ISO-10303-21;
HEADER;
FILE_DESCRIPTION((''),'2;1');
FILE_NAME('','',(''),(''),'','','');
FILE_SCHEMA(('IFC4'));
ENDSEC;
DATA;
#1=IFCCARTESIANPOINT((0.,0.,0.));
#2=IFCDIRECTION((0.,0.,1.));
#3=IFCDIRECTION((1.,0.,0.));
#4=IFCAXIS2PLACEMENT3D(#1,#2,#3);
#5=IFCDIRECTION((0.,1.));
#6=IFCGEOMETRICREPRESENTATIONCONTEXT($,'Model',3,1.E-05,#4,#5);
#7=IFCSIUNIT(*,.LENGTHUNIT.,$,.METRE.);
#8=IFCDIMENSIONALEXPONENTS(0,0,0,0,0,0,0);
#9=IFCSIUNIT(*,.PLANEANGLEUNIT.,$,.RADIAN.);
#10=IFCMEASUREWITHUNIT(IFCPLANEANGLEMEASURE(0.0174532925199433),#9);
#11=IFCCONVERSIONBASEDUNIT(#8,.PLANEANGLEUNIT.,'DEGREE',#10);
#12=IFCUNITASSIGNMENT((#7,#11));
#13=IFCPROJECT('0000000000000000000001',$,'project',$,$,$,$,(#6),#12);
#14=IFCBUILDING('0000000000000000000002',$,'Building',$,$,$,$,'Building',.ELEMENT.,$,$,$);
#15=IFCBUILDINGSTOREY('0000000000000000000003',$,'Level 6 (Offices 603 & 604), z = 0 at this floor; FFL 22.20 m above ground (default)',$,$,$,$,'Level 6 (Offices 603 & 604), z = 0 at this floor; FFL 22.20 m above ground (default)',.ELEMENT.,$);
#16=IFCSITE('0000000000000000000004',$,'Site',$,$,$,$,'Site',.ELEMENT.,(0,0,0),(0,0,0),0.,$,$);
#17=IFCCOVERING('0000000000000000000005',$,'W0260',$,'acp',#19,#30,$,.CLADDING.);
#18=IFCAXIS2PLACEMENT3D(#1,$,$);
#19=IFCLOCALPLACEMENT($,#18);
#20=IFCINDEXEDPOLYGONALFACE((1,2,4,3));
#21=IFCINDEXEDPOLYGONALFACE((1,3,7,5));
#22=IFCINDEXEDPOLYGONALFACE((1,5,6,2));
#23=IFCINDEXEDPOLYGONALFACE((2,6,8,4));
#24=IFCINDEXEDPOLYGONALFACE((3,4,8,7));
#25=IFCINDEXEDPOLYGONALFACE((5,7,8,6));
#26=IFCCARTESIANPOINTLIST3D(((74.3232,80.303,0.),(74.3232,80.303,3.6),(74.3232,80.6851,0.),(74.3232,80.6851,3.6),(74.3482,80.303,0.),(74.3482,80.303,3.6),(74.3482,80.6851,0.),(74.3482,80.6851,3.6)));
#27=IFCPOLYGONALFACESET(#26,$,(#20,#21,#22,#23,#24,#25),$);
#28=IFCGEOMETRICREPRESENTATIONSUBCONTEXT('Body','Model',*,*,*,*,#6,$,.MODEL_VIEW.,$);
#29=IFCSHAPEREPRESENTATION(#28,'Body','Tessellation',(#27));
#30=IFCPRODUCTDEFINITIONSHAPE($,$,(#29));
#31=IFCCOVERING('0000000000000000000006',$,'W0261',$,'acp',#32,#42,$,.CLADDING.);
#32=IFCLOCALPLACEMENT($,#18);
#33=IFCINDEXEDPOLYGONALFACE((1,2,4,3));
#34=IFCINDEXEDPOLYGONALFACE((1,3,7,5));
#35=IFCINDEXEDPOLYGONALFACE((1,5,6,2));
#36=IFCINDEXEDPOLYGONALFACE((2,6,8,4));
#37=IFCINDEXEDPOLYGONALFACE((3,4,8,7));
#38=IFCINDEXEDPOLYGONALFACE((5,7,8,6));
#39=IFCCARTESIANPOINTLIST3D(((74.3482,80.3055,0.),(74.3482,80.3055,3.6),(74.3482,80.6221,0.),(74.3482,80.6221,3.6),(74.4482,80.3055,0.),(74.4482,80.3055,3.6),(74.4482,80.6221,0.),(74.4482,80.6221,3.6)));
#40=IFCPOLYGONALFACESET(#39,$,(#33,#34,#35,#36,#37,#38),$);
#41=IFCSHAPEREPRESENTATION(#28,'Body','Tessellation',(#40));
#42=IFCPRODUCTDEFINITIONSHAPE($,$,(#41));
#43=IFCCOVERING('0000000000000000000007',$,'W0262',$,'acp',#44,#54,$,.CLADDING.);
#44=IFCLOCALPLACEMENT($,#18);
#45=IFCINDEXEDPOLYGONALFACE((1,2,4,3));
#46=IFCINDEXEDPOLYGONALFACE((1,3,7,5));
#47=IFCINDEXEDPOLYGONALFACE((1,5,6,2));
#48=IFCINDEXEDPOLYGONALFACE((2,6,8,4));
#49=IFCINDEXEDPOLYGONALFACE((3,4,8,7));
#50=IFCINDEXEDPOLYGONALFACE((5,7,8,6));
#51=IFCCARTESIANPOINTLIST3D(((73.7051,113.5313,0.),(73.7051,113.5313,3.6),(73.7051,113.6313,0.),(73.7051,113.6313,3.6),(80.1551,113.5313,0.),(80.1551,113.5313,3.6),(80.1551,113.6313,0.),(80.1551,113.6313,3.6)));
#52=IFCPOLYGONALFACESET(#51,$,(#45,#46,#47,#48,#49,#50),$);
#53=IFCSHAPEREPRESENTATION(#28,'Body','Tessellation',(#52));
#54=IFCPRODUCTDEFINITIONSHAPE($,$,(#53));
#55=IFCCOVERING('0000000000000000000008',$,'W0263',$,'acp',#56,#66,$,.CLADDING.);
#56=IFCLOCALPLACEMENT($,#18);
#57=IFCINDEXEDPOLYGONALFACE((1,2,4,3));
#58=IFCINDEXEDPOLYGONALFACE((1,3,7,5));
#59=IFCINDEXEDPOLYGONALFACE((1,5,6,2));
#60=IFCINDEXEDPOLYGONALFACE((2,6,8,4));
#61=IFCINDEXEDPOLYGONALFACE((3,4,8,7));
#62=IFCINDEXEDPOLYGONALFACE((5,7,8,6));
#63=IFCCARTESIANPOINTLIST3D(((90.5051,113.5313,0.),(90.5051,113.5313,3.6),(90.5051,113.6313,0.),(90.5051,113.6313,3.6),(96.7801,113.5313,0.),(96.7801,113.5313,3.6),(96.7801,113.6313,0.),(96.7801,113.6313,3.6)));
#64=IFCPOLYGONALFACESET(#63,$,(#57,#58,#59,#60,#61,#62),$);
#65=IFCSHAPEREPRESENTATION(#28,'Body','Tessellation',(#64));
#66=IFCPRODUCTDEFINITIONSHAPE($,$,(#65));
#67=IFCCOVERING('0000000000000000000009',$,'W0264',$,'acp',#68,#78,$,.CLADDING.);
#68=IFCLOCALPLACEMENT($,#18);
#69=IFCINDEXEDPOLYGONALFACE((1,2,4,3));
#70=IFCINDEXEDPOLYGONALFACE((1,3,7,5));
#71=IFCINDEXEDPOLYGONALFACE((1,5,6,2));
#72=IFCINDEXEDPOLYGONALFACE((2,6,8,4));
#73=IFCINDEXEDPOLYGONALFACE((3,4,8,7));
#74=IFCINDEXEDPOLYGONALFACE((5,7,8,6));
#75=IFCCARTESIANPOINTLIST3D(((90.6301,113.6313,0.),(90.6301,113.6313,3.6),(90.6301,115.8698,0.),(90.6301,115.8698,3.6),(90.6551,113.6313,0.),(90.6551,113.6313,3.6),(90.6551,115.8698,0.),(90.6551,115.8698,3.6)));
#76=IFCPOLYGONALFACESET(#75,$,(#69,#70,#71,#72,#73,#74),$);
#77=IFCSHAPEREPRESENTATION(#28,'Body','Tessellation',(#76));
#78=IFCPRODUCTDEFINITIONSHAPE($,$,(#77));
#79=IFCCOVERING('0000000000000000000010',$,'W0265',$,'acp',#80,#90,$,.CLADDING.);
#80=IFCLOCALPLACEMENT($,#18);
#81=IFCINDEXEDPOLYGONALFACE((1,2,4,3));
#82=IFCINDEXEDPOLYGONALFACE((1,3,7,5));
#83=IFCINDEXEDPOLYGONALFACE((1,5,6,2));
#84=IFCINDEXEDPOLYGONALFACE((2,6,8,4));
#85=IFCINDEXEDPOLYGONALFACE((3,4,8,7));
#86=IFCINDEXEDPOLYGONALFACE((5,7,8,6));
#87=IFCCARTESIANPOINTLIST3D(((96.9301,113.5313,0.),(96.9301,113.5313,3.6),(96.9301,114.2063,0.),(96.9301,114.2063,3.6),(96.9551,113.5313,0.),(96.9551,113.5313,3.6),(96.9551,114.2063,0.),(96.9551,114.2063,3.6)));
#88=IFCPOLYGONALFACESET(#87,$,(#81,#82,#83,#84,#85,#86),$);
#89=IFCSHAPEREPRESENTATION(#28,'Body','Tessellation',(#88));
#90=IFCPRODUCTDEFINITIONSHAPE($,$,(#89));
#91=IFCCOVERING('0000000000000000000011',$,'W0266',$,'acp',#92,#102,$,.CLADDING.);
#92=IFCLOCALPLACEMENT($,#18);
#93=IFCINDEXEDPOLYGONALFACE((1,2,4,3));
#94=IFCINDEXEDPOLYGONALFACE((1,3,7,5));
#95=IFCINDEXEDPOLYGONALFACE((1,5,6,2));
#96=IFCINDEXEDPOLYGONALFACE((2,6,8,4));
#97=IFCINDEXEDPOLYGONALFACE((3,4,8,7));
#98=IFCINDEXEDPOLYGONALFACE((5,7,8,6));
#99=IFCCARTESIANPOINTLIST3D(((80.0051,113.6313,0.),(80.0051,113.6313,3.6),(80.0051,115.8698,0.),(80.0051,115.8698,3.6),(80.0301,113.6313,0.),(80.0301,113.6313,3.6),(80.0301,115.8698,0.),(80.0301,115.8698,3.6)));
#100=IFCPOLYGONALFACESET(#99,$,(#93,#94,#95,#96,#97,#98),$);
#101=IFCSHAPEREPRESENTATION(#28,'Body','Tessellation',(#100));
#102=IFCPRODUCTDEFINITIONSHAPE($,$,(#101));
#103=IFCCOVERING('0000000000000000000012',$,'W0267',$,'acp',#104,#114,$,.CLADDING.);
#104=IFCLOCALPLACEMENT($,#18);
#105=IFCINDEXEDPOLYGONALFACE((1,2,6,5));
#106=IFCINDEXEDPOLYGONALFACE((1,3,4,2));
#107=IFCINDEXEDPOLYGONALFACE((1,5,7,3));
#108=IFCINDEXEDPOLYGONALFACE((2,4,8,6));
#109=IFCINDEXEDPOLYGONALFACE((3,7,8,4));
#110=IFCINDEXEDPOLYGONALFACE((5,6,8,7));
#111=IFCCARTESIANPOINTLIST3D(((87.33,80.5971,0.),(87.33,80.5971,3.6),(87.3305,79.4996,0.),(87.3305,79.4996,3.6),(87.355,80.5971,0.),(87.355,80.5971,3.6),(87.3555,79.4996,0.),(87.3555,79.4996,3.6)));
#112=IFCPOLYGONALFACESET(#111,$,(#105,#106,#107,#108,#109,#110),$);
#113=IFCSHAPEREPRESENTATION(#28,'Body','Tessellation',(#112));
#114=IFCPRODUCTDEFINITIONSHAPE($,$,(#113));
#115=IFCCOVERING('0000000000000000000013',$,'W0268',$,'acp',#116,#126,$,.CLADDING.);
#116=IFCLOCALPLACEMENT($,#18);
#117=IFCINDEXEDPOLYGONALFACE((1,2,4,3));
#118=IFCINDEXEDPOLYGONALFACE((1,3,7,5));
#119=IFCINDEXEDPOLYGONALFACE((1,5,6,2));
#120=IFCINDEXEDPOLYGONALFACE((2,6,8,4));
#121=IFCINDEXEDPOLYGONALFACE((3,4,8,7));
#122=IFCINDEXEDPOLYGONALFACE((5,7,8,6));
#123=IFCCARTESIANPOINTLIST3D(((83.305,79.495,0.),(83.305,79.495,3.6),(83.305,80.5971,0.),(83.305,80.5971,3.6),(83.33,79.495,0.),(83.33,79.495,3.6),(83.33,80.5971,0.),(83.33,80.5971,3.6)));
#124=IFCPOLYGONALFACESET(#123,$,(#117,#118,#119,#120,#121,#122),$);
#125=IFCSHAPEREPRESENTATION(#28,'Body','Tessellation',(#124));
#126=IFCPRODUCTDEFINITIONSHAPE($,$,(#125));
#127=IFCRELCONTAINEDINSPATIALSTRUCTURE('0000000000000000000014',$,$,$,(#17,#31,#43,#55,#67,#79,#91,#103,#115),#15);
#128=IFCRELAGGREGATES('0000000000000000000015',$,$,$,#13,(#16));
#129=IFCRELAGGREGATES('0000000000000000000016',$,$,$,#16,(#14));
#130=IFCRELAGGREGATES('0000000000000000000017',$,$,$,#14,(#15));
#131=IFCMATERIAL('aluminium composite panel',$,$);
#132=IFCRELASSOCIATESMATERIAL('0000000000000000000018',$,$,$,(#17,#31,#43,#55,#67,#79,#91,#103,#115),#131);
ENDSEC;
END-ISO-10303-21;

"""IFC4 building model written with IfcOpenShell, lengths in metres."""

from ifc_helpers import new_model, entity, si_unit, converted_unit, direction, frame, frame_2d, origin_with_axes, place, context, subcontext, project, spatial, rectangle, extrude, material, element, save


model = new_model("IFC4")

# Units and contexts
model_context = context("Model", 3, precision=1e-05, world=origin_with_axes(), true_north=direction((0.0, 1.0)))
body_context = subcontext(model_context, "Body", "Model", "MODEL_VIEW")
ifc_project = project(units=[si_unit("LENGTHUNIT", "METRE"), converted_unit("PLANEANGLEUNIT", "DEGREE", entity("IfcPlaneAngleMeasure", 0.0174532925199433), si_unit("PLANEANGLEUNIT", "RADIAN"), dimensions=[0, 0, 0, 0, 0, 0, 0])], contexts=[model_context])

# Site, building, storey
site = spatial("IfcSite", under=ifc_project, Name="Site", LongName="Site", CompositionType="ELEMENT", RefLatitude=(0, 0, 0), RefLongitude=(0, 0, 0), RefElevation=0.0)
building = spatial("IfcBuilding", under=site, Name="Building", LongName="Building", CompositionType="ELEMENT")
storey = spatial("IfcBuildingStorey", under=building, Name="Level 6 (Offices 603 & 604), z = 0 at this floor; FFL 22.20 m above ground (default)", LongName="Level 6 (Offices 603 & 604), z = 0 at this floor; FFL 22.20 m above ground (default)", CompositionType="ELEMENT")

# Shared definitions
placement = place(None, origin_with_axes())

# Coverings
ifc_material_1 = material(Name="aluminium composite panel")
element("IfcCovering", 1, at=placement, inside=storey, material=ifc_material_1, Name="W0260", ObjectType="acp", PredefinedType="CLADDING", context=body_context, shape_type="SweptSolid", body=[
    extrude(rectangle(XDim=0.3821, YDim=0.025, at=frame_2d((0.0, 0.0), x_axis=(0.0, 1.0))), frame((74.3357, 80.4941, 0.0), z_axis=(0.0, 0.0, 1.0), x_axis=(1.0, 0.0, 0.0)), (0.0, 0.0, 1.0), 3.6),
])
element("IfcCovering", 2, at=placement, inside=storey, material=ifc_material_1, Name="W0261", ObjectType="acp", PredefinedType="CLADDING", context=body_context, shape_type="SweptSolid", body=[
    extrude(rectangle(XDim=0.3166, YDim=0.1, at=frame_2d((0.0, 0.0), x_axis=(0.0, 1.0))), frame((74.3982, 80.4638, 0.0), z_axis=(0.0, 0.0, 1.0), x_axis=(1.0, 0.0, 0.0)), (0.0, 0.0, 1.0), 3.6),
])
element("IfcCovering", 3, at=placement, inside=storey, material=ifc_material_1, Name="W0262", ObjectType="acp", PredefinedType="CLADDING", context=body_context, shape_type="SweptSolid", body=[
    extrude(rectangle(XDim=6.45, YDim=0.1, at=frame_2d((0.0, 0.0), x_axis=(1.0, 0.0))), frame((76.9301, 113.5813, 0.0), z_axis=(0.0, 0.0, 1.0), x_axis=(1.0, 0.0, 0.0)), (0.0, 0.0, 1.0), 3.6),
])
element("IfcCovering", 4, at=placement, inside=storey, material=ifc_material_1, Name="W0263", ObjectType="acp", PredefinedType="CLADDING", context=body_context, shape_type="SweptSolid", body=[
    extrude(rectangle(XDim=6.275, YDim=0.1, at=frame_2d((0.0, 0.0), x_axis=(1.0, 0.0))), frame((93.6426, 113.5813, 0.0), z_axis=(0.0, 0.0, 1.0), x_axis=(1.0, 0.0, 0.0)), (0.0, 0.0, 1.0), 3.6),
])
element("IfcCovering", 5, at=placement, inside=storey, material=ifc_material_1, Name="W0264", ObjectType="acp", PredefinedType="CLADDING", context=body_context, shape_type="SweptSolid", body=[
    extrude(rectangle(XDim=2.2385, YDim=0.025, at=frame_2d((0.0, 0.0), x_axis=(0.0, 1.0))), frame((90.6426, 114.7506, 0.0), z_axis=(0.0, 0.0, 1.0), x_axis=(1.0, 0.0, 0.0)), (0.0, 0.0, 1.0), 3.6),
])
element("IfcCovering", 6, at=placement, inside=storey, material=ifc_material_1, Name="W0265", ObjectType="acp", PredefinedType="CLADDING", context=body_context, shape_type="SweptSolid", body=[
    extrude(rectangle(XDim=0.675, YDim=0.025, at=frame_2d((0.0, 0.0), x_axis=(0.0, 1.0))), frame((96.9426, 113.8688, 0.0), z_axis=(0.0, 0.0, 1.0), x_axis=(1.0, 0.0, 0.0)), (0.0, 0.0, 1.0), 3.6),
])
element("IfcCovering", 7, at=placement, inside=storey, material=ifc_material_1, Name="W0266", ObjectType="acp", PredefinedType="CLADDING", context=body_context, shape_type="SweptSolid", body=[
    extrude(rectangle(XDim=2.2385, YDim=0.025, at=frame_2d((0.0, 0.0), x_axis=(0.0, 1.0))), frame((80.0176, 114.7506, 0.0), z_axis=(0.0, 0.0, 1.0), x_axis=(1.0, 0.0, 0.0)), (0.0, 0.0, 1.0), 3.6),
])
element("IfcCovering", 8, at=placement, inside=storey, material=ifc_material_1, Name="W0267", ObjectType="acp", PredefinedType="CLADDING", context=body_context, shape_type="SweptSolid", body=[
    extrude(rectangle(XDim=1.0975, YDim=0.025, at=frame_2d((0.0, 0.0), x_axis=(0.000456, -1.0))), frame((87.3427, 80.0483, 0.0), z_axis=(0.0, 0.0, 1.0), x_axis=(1.0, 0.0, 0.0)), (0.0, 0.0, 1.0), 3.6),
])
element("IfcCovering", 9, at=placement, inside=storey, material=ifc_material_1, Name="W0268", ObjectType="acp", PredefinedType="CLADDING", context=body_context, shape_type="SweptSolid", body=[
    extrude(rectangle(XDim=1.1021, YDim=0.025, at=frame_2d((0.0, 0.0), x_axis=(0.0, 1.0))), frame((83.3175, 80.046, 0.0), z_axis=(0.0, 0.0, 1.0), x_axis=(1.0, 0.0, 0.0)), (0.0, 0.0, 1.0), 3.6),
])

save(model, "model.ifc")
